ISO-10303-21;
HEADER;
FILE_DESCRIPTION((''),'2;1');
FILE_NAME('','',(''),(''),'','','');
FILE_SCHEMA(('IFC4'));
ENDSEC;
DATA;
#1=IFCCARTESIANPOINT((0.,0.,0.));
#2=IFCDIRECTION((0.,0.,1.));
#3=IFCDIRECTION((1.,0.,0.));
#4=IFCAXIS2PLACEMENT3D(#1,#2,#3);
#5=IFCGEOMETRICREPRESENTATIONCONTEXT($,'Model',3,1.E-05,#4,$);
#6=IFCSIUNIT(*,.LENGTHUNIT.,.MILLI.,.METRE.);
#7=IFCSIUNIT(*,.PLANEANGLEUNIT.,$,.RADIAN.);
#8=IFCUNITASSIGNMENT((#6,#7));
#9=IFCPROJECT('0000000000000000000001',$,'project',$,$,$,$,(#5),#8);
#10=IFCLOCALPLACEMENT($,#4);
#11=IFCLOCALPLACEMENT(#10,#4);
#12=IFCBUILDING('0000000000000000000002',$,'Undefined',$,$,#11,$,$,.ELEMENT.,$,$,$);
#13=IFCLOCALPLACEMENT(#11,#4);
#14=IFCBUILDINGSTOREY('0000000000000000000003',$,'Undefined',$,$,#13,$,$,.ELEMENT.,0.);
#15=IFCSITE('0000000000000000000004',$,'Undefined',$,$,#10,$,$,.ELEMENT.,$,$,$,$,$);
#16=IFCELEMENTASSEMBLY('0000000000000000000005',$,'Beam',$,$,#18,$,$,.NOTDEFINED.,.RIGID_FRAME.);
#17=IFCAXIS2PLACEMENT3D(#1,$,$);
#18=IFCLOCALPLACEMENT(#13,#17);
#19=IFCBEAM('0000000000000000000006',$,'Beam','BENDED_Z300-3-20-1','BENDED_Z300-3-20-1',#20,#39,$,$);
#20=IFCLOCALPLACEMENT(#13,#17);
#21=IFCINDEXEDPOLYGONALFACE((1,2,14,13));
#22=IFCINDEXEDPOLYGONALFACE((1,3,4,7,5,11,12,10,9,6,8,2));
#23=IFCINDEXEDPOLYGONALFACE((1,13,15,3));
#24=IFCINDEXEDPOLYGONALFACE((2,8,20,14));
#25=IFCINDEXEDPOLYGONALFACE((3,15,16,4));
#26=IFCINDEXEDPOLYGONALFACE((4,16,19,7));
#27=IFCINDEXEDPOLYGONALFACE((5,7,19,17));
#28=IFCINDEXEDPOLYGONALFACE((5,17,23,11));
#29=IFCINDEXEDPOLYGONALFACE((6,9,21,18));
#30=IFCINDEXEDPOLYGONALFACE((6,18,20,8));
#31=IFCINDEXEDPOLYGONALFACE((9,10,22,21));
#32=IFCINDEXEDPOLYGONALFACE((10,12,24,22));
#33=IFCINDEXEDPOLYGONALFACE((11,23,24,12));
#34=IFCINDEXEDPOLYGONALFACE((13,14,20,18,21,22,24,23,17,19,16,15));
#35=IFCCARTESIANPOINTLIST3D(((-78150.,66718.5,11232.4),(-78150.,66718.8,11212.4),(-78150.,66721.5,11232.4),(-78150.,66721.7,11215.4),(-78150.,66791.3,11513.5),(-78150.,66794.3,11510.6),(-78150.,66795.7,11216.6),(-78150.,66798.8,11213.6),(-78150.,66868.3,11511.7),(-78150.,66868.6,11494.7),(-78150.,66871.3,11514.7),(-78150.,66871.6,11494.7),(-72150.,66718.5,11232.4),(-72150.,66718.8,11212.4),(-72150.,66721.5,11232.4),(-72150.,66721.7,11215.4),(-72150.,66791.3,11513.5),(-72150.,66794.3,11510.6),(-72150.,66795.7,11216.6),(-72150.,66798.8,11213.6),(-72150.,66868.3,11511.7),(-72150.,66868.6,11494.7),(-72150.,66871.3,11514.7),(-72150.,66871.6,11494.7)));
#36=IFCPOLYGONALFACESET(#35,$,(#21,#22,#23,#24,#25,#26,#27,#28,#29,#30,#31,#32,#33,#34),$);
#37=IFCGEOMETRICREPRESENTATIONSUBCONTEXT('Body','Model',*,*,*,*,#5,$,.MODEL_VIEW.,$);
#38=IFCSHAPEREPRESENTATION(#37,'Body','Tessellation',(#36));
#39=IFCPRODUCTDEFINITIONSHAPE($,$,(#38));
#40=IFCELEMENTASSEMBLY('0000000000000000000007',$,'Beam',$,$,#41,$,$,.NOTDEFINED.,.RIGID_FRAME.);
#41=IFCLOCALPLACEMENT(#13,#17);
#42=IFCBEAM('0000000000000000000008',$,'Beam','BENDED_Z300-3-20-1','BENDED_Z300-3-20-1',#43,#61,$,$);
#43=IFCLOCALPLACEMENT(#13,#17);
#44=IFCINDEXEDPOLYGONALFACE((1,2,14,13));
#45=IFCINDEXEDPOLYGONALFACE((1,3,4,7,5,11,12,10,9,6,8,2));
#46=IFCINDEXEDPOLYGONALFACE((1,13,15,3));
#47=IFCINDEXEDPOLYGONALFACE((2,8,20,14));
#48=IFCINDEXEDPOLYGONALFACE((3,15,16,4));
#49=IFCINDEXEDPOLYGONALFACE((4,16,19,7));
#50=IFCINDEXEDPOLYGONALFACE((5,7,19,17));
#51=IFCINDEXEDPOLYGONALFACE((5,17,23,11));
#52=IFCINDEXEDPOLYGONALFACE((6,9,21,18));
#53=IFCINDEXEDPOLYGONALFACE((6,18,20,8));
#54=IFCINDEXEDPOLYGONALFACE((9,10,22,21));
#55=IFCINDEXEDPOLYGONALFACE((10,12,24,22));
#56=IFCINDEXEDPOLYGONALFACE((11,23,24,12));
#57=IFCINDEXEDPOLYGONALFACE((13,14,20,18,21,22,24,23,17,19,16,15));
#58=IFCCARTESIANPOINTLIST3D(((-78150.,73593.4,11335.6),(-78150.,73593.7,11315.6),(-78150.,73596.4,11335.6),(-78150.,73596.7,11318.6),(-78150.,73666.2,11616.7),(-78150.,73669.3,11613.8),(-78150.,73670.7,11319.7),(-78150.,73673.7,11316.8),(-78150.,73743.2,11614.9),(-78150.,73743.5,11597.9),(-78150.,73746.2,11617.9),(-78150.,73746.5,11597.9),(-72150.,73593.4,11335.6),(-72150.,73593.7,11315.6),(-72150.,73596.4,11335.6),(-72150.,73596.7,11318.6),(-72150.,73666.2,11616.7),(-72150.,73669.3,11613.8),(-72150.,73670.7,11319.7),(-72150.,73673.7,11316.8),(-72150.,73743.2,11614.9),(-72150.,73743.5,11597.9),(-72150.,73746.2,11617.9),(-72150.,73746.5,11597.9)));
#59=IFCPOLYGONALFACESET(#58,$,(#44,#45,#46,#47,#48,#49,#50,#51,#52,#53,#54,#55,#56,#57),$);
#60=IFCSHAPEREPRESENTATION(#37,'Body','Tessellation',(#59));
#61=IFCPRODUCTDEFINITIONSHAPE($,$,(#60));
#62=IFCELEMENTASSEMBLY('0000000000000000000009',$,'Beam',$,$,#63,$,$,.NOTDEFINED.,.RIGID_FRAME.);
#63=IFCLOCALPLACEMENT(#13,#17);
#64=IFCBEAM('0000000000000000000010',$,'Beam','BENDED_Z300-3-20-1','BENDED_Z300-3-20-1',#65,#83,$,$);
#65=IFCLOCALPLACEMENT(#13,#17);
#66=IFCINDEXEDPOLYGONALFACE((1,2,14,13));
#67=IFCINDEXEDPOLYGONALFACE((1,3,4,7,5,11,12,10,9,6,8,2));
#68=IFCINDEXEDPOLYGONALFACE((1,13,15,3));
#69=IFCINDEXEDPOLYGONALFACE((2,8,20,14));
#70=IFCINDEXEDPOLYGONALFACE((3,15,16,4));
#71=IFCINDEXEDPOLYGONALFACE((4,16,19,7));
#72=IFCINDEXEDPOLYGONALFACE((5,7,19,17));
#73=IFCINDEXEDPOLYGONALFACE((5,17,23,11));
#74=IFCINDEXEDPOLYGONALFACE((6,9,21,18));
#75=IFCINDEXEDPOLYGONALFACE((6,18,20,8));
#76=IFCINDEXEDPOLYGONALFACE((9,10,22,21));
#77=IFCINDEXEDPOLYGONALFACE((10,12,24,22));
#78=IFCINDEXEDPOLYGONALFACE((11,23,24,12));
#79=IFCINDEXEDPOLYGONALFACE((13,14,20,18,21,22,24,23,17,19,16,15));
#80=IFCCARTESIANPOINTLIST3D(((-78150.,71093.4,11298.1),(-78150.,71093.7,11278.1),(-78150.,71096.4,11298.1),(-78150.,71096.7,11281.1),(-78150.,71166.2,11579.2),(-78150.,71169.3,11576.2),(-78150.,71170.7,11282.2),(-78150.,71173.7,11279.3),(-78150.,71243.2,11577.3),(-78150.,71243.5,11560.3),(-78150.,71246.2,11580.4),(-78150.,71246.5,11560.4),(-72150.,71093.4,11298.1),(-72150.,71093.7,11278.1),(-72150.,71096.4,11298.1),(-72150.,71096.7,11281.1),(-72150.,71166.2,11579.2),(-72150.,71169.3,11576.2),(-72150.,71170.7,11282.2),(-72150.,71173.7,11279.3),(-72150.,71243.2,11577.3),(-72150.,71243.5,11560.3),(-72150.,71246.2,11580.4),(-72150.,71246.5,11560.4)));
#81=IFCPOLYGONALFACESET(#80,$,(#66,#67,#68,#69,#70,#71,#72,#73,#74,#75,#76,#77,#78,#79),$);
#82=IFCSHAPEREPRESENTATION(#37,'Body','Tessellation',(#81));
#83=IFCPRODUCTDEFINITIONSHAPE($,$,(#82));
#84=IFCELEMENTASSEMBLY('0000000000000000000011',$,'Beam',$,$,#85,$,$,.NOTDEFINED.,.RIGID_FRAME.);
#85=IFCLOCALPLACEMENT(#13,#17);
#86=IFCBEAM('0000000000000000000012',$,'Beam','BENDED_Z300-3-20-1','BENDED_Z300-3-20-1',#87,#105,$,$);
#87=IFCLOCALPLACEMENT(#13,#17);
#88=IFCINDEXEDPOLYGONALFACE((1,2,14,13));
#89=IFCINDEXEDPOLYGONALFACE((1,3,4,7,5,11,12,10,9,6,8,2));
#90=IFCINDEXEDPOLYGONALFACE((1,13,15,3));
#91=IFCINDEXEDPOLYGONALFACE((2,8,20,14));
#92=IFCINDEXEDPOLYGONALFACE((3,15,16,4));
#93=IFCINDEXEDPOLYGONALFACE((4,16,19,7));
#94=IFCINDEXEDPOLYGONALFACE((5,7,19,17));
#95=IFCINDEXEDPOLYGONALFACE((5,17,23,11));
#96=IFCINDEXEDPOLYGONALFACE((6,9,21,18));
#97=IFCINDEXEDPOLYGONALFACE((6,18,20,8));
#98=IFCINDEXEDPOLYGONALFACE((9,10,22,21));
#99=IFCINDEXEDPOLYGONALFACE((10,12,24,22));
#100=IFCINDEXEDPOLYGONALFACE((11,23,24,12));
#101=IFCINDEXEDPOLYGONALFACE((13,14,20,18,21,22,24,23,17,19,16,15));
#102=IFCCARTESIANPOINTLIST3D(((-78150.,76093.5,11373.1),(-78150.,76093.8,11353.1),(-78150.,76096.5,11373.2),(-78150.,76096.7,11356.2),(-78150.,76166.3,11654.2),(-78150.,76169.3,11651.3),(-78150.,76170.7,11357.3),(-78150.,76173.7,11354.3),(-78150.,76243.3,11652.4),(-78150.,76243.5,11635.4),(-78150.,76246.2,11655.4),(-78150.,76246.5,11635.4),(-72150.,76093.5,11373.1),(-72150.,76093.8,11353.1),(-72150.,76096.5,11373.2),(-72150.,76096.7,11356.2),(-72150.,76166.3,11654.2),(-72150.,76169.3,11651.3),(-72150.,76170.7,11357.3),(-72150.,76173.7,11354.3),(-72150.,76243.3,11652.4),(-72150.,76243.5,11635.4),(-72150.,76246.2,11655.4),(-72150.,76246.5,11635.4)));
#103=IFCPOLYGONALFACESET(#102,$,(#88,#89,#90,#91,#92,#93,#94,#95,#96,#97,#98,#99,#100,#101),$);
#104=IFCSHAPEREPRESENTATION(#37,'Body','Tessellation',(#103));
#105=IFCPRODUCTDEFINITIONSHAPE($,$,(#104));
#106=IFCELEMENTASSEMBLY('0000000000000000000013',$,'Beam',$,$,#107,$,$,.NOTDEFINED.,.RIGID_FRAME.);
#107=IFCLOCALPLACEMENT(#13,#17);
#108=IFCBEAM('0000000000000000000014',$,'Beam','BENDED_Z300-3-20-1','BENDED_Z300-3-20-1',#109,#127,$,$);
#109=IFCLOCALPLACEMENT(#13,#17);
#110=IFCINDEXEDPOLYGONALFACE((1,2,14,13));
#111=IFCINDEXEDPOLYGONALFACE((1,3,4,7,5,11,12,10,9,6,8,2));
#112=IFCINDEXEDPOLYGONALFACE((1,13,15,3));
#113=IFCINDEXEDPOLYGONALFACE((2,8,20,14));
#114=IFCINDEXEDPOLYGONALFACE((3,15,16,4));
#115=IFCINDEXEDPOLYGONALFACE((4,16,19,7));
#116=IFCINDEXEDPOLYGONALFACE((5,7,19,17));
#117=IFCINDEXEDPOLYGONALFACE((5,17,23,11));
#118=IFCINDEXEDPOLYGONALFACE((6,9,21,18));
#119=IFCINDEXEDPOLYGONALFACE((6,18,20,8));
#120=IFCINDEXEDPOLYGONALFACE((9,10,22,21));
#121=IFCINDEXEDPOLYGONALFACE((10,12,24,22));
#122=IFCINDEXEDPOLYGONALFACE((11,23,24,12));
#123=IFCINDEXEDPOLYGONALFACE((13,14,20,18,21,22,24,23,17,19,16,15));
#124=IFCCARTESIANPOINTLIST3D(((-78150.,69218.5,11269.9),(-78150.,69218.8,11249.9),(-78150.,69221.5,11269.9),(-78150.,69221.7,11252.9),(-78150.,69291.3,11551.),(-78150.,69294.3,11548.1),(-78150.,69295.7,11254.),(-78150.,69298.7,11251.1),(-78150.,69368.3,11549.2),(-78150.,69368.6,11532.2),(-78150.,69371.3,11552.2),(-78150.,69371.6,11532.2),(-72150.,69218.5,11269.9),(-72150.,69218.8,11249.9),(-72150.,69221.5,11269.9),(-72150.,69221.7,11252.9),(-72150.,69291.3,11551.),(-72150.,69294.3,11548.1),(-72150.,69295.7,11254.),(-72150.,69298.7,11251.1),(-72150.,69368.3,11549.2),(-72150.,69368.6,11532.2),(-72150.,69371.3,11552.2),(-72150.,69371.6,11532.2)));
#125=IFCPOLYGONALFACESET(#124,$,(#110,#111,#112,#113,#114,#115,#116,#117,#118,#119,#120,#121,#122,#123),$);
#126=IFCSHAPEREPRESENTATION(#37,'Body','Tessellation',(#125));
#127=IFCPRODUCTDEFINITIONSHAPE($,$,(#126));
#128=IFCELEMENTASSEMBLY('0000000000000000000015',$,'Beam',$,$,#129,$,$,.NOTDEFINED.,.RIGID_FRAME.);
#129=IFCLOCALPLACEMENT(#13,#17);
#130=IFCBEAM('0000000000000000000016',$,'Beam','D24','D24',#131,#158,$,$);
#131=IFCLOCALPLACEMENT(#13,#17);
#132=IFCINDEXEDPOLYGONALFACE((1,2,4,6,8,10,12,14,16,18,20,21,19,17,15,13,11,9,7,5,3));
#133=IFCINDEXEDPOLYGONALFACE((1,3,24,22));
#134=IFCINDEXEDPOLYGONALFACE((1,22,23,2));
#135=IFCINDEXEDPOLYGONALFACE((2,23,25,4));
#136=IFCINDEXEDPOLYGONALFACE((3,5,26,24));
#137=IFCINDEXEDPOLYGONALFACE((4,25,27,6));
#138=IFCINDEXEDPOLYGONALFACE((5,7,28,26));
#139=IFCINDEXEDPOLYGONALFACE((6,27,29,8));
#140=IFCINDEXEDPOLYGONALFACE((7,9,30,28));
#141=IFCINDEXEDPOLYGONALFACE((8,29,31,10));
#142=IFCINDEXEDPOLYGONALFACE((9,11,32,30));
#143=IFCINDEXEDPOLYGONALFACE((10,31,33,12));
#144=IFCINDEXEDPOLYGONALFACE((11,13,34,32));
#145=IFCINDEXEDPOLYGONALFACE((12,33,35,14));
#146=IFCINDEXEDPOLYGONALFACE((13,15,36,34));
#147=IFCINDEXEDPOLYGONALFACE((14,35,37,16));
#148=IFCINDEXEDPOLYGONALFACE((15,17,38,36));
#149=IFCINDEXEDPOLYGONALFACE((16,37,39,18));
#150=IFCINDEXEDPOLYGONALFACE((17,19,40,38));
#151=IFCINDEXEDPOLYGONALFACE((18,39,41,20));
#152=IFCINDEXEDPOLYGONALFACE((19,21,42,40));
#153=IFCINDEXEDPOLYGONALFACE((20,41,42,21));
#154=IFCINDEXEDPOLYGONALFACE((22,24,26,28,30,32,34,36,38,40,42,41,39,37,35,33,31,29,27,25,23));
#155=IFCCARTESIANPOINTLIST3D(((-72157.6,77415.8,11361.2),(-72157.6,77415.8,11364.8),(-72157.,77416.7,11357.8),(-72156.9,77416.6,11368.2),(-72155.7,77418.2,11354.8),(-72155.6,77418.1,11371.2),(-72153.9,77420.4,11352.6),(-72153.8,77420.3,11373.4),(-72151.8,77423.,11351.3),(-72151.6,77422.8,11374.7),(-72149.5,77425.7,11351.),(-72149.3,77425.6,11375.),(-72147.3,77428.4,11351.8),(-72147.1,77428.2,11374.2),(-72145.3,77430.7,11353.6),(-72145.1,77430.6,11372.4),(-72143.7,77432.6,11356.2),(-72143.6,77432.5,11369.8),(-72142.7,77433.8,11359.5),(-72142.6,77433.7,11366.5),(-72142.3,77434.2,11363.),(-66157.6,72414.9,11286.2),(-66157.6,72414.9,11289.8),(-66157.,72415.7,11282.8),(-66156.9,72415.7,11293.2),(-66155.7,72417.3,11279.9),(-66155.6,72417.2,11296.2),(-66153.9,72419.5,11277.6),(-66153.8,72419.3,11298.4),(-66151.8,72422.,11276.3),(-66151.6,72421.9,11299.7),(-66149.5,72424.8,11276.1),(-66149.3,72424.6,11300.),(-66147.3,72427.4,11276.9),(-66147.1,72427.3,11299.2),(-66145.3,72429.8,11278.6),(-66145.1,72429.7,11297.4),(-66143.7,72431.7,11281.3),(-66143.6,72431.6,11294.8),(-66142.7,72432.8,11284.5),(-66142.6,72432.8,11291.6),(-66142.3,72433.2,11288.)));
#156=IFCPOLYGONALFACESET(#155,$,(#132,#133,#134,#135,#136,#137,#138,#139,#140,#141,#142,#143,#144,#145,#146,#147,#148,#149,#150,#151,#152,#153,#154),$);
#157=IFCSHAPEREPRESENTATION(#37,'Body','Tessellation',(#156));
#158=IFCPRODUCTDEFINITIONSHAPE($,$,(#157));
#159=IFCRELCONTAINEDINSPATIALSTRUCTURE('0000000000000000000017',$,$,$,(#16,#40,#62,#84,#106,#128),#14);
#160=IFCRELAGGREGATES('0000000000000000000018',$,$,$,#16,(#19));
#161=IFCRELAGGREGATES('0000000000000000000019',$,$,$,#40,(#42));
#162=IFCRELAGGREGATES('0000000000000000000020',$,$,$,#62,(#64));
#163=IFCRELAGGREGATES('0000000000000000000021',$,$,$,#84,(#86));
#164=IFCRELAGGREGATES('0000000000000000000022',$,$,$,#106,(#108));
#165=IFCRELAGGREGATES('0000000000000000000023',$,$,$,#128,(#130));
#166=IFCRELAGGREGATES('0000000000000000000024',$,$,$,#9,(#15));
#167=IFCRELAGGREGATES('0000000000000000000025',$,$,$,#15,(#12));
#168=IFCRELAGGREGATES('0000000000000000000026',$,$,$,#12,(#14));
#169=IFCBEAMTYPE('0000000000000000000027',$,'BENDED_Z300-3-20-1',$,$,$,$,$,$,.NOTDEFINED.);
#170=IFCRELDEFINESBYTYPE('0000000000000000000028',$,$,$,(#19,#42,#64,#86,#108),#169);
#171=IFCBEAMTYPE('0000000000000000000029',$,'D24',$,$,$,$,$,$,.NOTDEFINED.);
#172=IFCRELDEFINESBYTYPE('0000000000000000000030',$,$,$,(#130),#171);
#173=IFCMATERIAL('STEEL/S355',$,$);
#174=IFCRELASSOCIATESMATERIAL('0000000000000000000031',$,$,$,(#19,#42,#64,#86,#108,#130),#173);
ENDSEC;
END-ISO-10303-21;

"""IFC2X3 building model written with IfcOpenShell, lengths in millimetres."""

from ifc_helpers import new_model, si_unit, frame, origin_with_axes, origin_2d_with_axis, place, context, subcontext, project, spatial, polyline, circle, outline, extrude, material, type_object, element, aggregate, save


model = new_model("IFC2X3")

# Units and contexts
model_context = context("Model", 3, precision=1e-05, world=origin_with_axes())
body_context = subcontext(model_context, "Body", "Model", "MODEL_VIEW")
ifc_project = project(units=[si_unit("LENGTHUNIT", "METRE", prefix="MILLI"), si_unit("PLANEANGLEUNIT", "RADIAN")], contexts=[model_context])

# Site, building, storey
site_placement = place(None, origin_with_axes())
site = spatial("IfcSite", under=ifc_project, at=site_placement, Name="Undefined", CompositionType="ELEMENT")
building_placement = place(site_placement, origin_with_axes())
building = spatial("IfcBuilding", under=site, at=building_placement, Name="Undefined", CompositionType="ELEMENT")
storey_placement = place(building_placement, origin_with_axes())
storey = spatial("IfcBuildingStorey", under=building, at=storey_placement, Name="Undefined", CompositionType="ELEMENT", Elevation=0.0)

# Element assemblies, beams
ifc_material = material(Name="STEEL/S355")
beam_type_1 = type_object("IfcBeamType", Name="BENDED_Z300-3-20-1", PredefinedType="NOTDEFINED")
assembly_1_placement = place(storey_placement, origin_with_axes())
assembly_1 = element("IfcElementAssembly", 1, at=assembly_1_placement, inside=storey, Name="Beam", AssemblyPlace="NOTDEFINED", PredefinedType="RIGID_FRAME")
beam_1_placement = place(assembly_1_placement, frame((-72150.0, 66795.0, 11363.6), z_axis=(0.0, -0.014963, 0.999888), x_axis=(-1.0, 0.0, 0.0)))
beam_1 = element("IfcBeam", 2, at=beam_1_placement, type_object=beam_type_1, material=ifc_material, Name="Beam", Description="BENDED_Z300-3-20-1", ObjectType="BENDED_Z300-3-20-1", context=body_context, shape_type="SweptSolid", body=[
    extrude(outline(polyline([(1.5, -150.0), (-78.5, -150.0), (-78.5, -130.0), (-75.5, -130.0), (-75.5, -147.0), (-1.5, -147.0), (-1.5, 150.0), (78.5, 150.0), (78.5, 130.0), (75.5, 130.0), (75.5, 147.0), (1.5, 147.0), (1.5, -150.0)])), frame((6000.0, 0.0, 0.0), z_axis=(-1.0, 0.0, 0.0), x_axis=(0.0, -1.0, 0.0)), (0.0, 0.0, 1.0), 6000.0),
])
aggregate(assembly_1, [beam_1])
assembly_2_placement = place(storey_placement, origin_with_axes())
assembly_2 = element("IfcElementAssembly", 3, at=assembly_2_placement, inside=storey, Name="Beam", AssemblyPlace="NOTDEFINED", PredefinedType="RIGID_FRAME")
beam_2_placement = place(assembly_2_placement, frame((-72150.0, 73670.0, 11466.8), z_axis=(0.0, -0.014963, 0.999888), x_axis=(-1.0, 0.0, 0.0)))
beam_2 = element("IfcBeam", 4, at=beam_2_placement, type_object=beam_type_1, material=ifc_material, Name="Beam", Description="BENDED_Z300-3-20-1", ObjectType="BENDED_Z300-3-20-1", context=body_context, shape_type="SweptSolid", body=[
    extrude(outline(polyline([(1.5, -150.0), (-78.5, -150.0), (-78.5, -130.0), (-75.5, -130.0), (-75.5, -147.0), (-1.5, -147.0), (-1.5, 150.0), (78.5, 150.0), (78.5, 130.0), (75.5, 130.0), (75.5, 147.0), (1.5, 147.0), (1.5, -150.0)])), frame((6000.0, 0.0, 0.0), z_axis=(-1.0, 0.0, 0.0), x_axis=(0.0, -1.0, 0.0)), (0.0, 0.0, 1.0), 6000.0),
])
aggregate(assembly_2, [beam_2])
assembly_3_placement = place(storey_placement, origin_with_axes())
assembly_3 = element("IfcElementAssembly", 5, at=assembly_3_placement, inside=storey, Name="Beam", AssemblyPlace="NOTDEFINED", PredefinedType="RIGID_FRAME")
beam_3_placement = place(assembly_3_placement, frame((-72150.0, 71170.0, 11429.2), z_axis=(0.0, -0.014963, 0.999888), x_axis=(-1.0, 0.0, 0.0)))
beam_3 = element("IfcBeam", 6, at=beam_3_placement, type_object=beam_type_1, material=ifc_material, Name="Beam", Description="BENDED_Z300-3-20-1", ObjectType="BENDED_Z300-3-20-1", context=body_context, shape_type="SweptSolid", body=[
    extrude(outline(polyline([(1.5, -150.0), (-78.5, -150.0), (-78.5, -130.0), (-75.5, -130.0), (-75.5, -147.0), (-1.5, -147.0), (-1.5, 150.0), (78.5, 150.0), (78.5, 130.0), (75.5, 130.0), (75.5, 147.0), (1.5, 147.0), (1.5, -150.0)])), frame((6000.0, 0.0, 0.0), z_axis=(-1.0, 0.0, 0.0), x_axis=(0.0, -1.0, 0.0)), (0.0, 0.0, 1.0), 6000.0),
])
aggregate(assembly_3, [beam_3])
assembly_4_placement = place(storey_placement, origin_with_axes())
assembly_4 = element("IfcElementAssembly", 7, at=assembly_4_placement, inside=storey, Name="Beam", AssemblyPlace="NOTDEFINED", PredefinedType="RIGID_FRAME")
beam_4_placement = place(assembly_4_placement, frame((-72150.0, 76170.0, 11504.3), z_axis=(0.0, -0.014963, 0.999888), x_axis=(-1.0, 0.0, 0.0)))
beam_4 = element("IfcBeam", 8, at=beam_4_placement, type_object=beam_type_1, material=ifc_material, Name="Beam", Description="BENDED_Z300-3-20-1", ObjectType="BENDED_Z300-3-20-1", context=body_context, shape_type="SweptSolid", body=[
    extrude(outline(polyline([(1.5, -150.0), (-78.5, -150.0), (-78.5, -130.0), (-75.5, -130.0), (-75.5, -147.0), (-1.5, -147.0), (-1.5, 150.0), (78.5, 150.0), (78.5, 130.0), (75.5, 130.0), (75.5, 147.0), (1.5, 147.0), (1.5, -150.0)])), frame((6000.0, 0.0, 0.0), z_axis=(-1.0, 0.0, 0.0), x_axis=(0.0, -1.0, 0.0)), (0.0, 0.0, 1.0), 6000.0),
])
aggregate(assembly_4, [beam_4])
assembly_5_placement = place(storey_placement, origin_with_axes())
assembly_5 = element("IfcElementAssembly", 9, at=assembly_5_placement, inside=storey, Name="Beam", AssemblyPlace="NOTDEFINED", PredefinedType="RIGID_FRAME")
beam_5_placement = place(assembly_5_placement, frame((-72150.0, 69295.0, 11401.1), z_axis=(0.0, -0.014963, 0.999888), x_axis=(-1.0, 0.0, 0.0)))
beam_5 = element("IfcBeam", 10, at=beam_5_placement, type_object=beam_type_1, material=ifc_material, Name="Beam", Description="BENDED_Z300-3-20-1", ObjectType="BENDED_Z300-3-20-1", context=body_context, shape_type="SweptSolid", body=[
    extrude(outline(polyline([(1.5, -150.0), (-78.5, -150.0), (-78.5, -130.0), (-75.5, -130.0), (-75.5, -147.0), (-1.5, -147.0), (-1.5, 150.0), (78.5, 150.0), (78.5, 130.0), (75.5, 130.0), (75.5, 147.0), (1.5, 147.0), (1.5, -150.0)])), frame((6000.0, 0.0, 0.0), z_axis=(-1.0, 0.0, 0.0), x_axis=(0.0, -1.0, 0.0)), (0.0, 0.0, 1.0), 6000.0),
])
aggregate(assembly_5, [beam_5])
assembly_6_placement = place(storey_placement, origin_with_axes())
assembly_6 = element("IfcElementAssembly", 11, at=assembly_6_placement, inside=storey, Name="Beam", AssemblyPlace="NOTDEFINED", PredefinedType="RIGID_FRAME")
beam_type_2 = type_object("IfcBeamType", Name="D24", PredefinedType="NOTDEFINED")
beam_6_placement = place(assembly_6_placement, frame((-66150.0, 72424.0, 11288.0), z_axis=(0.007372, -0.006145, 0.999954), x_axis=(-0.768127, 0.640225, 0.009598)))
beam_6 = element("IfcBeam", 12, at=beam_6_placement, type_object=beam_type_2, material=ifc_material, Name="Beam", Description="D24", ObjectType="D24", context=body_context, shape_type="SweptSolid", body=[
    extrude(circle(Radius=12.0, at=origin_2d_with_axis()), frame((7811.2, 0.0, 0.0), z_axis=(-1.0, 0.0, 0.0), x_axis=(0.0, -1.0, 0.0)), (0.0, 0.0, 1.0), 7811.2),
])
aggregate(assembly_6, [beam_6])

save(model, "model.ifc")
